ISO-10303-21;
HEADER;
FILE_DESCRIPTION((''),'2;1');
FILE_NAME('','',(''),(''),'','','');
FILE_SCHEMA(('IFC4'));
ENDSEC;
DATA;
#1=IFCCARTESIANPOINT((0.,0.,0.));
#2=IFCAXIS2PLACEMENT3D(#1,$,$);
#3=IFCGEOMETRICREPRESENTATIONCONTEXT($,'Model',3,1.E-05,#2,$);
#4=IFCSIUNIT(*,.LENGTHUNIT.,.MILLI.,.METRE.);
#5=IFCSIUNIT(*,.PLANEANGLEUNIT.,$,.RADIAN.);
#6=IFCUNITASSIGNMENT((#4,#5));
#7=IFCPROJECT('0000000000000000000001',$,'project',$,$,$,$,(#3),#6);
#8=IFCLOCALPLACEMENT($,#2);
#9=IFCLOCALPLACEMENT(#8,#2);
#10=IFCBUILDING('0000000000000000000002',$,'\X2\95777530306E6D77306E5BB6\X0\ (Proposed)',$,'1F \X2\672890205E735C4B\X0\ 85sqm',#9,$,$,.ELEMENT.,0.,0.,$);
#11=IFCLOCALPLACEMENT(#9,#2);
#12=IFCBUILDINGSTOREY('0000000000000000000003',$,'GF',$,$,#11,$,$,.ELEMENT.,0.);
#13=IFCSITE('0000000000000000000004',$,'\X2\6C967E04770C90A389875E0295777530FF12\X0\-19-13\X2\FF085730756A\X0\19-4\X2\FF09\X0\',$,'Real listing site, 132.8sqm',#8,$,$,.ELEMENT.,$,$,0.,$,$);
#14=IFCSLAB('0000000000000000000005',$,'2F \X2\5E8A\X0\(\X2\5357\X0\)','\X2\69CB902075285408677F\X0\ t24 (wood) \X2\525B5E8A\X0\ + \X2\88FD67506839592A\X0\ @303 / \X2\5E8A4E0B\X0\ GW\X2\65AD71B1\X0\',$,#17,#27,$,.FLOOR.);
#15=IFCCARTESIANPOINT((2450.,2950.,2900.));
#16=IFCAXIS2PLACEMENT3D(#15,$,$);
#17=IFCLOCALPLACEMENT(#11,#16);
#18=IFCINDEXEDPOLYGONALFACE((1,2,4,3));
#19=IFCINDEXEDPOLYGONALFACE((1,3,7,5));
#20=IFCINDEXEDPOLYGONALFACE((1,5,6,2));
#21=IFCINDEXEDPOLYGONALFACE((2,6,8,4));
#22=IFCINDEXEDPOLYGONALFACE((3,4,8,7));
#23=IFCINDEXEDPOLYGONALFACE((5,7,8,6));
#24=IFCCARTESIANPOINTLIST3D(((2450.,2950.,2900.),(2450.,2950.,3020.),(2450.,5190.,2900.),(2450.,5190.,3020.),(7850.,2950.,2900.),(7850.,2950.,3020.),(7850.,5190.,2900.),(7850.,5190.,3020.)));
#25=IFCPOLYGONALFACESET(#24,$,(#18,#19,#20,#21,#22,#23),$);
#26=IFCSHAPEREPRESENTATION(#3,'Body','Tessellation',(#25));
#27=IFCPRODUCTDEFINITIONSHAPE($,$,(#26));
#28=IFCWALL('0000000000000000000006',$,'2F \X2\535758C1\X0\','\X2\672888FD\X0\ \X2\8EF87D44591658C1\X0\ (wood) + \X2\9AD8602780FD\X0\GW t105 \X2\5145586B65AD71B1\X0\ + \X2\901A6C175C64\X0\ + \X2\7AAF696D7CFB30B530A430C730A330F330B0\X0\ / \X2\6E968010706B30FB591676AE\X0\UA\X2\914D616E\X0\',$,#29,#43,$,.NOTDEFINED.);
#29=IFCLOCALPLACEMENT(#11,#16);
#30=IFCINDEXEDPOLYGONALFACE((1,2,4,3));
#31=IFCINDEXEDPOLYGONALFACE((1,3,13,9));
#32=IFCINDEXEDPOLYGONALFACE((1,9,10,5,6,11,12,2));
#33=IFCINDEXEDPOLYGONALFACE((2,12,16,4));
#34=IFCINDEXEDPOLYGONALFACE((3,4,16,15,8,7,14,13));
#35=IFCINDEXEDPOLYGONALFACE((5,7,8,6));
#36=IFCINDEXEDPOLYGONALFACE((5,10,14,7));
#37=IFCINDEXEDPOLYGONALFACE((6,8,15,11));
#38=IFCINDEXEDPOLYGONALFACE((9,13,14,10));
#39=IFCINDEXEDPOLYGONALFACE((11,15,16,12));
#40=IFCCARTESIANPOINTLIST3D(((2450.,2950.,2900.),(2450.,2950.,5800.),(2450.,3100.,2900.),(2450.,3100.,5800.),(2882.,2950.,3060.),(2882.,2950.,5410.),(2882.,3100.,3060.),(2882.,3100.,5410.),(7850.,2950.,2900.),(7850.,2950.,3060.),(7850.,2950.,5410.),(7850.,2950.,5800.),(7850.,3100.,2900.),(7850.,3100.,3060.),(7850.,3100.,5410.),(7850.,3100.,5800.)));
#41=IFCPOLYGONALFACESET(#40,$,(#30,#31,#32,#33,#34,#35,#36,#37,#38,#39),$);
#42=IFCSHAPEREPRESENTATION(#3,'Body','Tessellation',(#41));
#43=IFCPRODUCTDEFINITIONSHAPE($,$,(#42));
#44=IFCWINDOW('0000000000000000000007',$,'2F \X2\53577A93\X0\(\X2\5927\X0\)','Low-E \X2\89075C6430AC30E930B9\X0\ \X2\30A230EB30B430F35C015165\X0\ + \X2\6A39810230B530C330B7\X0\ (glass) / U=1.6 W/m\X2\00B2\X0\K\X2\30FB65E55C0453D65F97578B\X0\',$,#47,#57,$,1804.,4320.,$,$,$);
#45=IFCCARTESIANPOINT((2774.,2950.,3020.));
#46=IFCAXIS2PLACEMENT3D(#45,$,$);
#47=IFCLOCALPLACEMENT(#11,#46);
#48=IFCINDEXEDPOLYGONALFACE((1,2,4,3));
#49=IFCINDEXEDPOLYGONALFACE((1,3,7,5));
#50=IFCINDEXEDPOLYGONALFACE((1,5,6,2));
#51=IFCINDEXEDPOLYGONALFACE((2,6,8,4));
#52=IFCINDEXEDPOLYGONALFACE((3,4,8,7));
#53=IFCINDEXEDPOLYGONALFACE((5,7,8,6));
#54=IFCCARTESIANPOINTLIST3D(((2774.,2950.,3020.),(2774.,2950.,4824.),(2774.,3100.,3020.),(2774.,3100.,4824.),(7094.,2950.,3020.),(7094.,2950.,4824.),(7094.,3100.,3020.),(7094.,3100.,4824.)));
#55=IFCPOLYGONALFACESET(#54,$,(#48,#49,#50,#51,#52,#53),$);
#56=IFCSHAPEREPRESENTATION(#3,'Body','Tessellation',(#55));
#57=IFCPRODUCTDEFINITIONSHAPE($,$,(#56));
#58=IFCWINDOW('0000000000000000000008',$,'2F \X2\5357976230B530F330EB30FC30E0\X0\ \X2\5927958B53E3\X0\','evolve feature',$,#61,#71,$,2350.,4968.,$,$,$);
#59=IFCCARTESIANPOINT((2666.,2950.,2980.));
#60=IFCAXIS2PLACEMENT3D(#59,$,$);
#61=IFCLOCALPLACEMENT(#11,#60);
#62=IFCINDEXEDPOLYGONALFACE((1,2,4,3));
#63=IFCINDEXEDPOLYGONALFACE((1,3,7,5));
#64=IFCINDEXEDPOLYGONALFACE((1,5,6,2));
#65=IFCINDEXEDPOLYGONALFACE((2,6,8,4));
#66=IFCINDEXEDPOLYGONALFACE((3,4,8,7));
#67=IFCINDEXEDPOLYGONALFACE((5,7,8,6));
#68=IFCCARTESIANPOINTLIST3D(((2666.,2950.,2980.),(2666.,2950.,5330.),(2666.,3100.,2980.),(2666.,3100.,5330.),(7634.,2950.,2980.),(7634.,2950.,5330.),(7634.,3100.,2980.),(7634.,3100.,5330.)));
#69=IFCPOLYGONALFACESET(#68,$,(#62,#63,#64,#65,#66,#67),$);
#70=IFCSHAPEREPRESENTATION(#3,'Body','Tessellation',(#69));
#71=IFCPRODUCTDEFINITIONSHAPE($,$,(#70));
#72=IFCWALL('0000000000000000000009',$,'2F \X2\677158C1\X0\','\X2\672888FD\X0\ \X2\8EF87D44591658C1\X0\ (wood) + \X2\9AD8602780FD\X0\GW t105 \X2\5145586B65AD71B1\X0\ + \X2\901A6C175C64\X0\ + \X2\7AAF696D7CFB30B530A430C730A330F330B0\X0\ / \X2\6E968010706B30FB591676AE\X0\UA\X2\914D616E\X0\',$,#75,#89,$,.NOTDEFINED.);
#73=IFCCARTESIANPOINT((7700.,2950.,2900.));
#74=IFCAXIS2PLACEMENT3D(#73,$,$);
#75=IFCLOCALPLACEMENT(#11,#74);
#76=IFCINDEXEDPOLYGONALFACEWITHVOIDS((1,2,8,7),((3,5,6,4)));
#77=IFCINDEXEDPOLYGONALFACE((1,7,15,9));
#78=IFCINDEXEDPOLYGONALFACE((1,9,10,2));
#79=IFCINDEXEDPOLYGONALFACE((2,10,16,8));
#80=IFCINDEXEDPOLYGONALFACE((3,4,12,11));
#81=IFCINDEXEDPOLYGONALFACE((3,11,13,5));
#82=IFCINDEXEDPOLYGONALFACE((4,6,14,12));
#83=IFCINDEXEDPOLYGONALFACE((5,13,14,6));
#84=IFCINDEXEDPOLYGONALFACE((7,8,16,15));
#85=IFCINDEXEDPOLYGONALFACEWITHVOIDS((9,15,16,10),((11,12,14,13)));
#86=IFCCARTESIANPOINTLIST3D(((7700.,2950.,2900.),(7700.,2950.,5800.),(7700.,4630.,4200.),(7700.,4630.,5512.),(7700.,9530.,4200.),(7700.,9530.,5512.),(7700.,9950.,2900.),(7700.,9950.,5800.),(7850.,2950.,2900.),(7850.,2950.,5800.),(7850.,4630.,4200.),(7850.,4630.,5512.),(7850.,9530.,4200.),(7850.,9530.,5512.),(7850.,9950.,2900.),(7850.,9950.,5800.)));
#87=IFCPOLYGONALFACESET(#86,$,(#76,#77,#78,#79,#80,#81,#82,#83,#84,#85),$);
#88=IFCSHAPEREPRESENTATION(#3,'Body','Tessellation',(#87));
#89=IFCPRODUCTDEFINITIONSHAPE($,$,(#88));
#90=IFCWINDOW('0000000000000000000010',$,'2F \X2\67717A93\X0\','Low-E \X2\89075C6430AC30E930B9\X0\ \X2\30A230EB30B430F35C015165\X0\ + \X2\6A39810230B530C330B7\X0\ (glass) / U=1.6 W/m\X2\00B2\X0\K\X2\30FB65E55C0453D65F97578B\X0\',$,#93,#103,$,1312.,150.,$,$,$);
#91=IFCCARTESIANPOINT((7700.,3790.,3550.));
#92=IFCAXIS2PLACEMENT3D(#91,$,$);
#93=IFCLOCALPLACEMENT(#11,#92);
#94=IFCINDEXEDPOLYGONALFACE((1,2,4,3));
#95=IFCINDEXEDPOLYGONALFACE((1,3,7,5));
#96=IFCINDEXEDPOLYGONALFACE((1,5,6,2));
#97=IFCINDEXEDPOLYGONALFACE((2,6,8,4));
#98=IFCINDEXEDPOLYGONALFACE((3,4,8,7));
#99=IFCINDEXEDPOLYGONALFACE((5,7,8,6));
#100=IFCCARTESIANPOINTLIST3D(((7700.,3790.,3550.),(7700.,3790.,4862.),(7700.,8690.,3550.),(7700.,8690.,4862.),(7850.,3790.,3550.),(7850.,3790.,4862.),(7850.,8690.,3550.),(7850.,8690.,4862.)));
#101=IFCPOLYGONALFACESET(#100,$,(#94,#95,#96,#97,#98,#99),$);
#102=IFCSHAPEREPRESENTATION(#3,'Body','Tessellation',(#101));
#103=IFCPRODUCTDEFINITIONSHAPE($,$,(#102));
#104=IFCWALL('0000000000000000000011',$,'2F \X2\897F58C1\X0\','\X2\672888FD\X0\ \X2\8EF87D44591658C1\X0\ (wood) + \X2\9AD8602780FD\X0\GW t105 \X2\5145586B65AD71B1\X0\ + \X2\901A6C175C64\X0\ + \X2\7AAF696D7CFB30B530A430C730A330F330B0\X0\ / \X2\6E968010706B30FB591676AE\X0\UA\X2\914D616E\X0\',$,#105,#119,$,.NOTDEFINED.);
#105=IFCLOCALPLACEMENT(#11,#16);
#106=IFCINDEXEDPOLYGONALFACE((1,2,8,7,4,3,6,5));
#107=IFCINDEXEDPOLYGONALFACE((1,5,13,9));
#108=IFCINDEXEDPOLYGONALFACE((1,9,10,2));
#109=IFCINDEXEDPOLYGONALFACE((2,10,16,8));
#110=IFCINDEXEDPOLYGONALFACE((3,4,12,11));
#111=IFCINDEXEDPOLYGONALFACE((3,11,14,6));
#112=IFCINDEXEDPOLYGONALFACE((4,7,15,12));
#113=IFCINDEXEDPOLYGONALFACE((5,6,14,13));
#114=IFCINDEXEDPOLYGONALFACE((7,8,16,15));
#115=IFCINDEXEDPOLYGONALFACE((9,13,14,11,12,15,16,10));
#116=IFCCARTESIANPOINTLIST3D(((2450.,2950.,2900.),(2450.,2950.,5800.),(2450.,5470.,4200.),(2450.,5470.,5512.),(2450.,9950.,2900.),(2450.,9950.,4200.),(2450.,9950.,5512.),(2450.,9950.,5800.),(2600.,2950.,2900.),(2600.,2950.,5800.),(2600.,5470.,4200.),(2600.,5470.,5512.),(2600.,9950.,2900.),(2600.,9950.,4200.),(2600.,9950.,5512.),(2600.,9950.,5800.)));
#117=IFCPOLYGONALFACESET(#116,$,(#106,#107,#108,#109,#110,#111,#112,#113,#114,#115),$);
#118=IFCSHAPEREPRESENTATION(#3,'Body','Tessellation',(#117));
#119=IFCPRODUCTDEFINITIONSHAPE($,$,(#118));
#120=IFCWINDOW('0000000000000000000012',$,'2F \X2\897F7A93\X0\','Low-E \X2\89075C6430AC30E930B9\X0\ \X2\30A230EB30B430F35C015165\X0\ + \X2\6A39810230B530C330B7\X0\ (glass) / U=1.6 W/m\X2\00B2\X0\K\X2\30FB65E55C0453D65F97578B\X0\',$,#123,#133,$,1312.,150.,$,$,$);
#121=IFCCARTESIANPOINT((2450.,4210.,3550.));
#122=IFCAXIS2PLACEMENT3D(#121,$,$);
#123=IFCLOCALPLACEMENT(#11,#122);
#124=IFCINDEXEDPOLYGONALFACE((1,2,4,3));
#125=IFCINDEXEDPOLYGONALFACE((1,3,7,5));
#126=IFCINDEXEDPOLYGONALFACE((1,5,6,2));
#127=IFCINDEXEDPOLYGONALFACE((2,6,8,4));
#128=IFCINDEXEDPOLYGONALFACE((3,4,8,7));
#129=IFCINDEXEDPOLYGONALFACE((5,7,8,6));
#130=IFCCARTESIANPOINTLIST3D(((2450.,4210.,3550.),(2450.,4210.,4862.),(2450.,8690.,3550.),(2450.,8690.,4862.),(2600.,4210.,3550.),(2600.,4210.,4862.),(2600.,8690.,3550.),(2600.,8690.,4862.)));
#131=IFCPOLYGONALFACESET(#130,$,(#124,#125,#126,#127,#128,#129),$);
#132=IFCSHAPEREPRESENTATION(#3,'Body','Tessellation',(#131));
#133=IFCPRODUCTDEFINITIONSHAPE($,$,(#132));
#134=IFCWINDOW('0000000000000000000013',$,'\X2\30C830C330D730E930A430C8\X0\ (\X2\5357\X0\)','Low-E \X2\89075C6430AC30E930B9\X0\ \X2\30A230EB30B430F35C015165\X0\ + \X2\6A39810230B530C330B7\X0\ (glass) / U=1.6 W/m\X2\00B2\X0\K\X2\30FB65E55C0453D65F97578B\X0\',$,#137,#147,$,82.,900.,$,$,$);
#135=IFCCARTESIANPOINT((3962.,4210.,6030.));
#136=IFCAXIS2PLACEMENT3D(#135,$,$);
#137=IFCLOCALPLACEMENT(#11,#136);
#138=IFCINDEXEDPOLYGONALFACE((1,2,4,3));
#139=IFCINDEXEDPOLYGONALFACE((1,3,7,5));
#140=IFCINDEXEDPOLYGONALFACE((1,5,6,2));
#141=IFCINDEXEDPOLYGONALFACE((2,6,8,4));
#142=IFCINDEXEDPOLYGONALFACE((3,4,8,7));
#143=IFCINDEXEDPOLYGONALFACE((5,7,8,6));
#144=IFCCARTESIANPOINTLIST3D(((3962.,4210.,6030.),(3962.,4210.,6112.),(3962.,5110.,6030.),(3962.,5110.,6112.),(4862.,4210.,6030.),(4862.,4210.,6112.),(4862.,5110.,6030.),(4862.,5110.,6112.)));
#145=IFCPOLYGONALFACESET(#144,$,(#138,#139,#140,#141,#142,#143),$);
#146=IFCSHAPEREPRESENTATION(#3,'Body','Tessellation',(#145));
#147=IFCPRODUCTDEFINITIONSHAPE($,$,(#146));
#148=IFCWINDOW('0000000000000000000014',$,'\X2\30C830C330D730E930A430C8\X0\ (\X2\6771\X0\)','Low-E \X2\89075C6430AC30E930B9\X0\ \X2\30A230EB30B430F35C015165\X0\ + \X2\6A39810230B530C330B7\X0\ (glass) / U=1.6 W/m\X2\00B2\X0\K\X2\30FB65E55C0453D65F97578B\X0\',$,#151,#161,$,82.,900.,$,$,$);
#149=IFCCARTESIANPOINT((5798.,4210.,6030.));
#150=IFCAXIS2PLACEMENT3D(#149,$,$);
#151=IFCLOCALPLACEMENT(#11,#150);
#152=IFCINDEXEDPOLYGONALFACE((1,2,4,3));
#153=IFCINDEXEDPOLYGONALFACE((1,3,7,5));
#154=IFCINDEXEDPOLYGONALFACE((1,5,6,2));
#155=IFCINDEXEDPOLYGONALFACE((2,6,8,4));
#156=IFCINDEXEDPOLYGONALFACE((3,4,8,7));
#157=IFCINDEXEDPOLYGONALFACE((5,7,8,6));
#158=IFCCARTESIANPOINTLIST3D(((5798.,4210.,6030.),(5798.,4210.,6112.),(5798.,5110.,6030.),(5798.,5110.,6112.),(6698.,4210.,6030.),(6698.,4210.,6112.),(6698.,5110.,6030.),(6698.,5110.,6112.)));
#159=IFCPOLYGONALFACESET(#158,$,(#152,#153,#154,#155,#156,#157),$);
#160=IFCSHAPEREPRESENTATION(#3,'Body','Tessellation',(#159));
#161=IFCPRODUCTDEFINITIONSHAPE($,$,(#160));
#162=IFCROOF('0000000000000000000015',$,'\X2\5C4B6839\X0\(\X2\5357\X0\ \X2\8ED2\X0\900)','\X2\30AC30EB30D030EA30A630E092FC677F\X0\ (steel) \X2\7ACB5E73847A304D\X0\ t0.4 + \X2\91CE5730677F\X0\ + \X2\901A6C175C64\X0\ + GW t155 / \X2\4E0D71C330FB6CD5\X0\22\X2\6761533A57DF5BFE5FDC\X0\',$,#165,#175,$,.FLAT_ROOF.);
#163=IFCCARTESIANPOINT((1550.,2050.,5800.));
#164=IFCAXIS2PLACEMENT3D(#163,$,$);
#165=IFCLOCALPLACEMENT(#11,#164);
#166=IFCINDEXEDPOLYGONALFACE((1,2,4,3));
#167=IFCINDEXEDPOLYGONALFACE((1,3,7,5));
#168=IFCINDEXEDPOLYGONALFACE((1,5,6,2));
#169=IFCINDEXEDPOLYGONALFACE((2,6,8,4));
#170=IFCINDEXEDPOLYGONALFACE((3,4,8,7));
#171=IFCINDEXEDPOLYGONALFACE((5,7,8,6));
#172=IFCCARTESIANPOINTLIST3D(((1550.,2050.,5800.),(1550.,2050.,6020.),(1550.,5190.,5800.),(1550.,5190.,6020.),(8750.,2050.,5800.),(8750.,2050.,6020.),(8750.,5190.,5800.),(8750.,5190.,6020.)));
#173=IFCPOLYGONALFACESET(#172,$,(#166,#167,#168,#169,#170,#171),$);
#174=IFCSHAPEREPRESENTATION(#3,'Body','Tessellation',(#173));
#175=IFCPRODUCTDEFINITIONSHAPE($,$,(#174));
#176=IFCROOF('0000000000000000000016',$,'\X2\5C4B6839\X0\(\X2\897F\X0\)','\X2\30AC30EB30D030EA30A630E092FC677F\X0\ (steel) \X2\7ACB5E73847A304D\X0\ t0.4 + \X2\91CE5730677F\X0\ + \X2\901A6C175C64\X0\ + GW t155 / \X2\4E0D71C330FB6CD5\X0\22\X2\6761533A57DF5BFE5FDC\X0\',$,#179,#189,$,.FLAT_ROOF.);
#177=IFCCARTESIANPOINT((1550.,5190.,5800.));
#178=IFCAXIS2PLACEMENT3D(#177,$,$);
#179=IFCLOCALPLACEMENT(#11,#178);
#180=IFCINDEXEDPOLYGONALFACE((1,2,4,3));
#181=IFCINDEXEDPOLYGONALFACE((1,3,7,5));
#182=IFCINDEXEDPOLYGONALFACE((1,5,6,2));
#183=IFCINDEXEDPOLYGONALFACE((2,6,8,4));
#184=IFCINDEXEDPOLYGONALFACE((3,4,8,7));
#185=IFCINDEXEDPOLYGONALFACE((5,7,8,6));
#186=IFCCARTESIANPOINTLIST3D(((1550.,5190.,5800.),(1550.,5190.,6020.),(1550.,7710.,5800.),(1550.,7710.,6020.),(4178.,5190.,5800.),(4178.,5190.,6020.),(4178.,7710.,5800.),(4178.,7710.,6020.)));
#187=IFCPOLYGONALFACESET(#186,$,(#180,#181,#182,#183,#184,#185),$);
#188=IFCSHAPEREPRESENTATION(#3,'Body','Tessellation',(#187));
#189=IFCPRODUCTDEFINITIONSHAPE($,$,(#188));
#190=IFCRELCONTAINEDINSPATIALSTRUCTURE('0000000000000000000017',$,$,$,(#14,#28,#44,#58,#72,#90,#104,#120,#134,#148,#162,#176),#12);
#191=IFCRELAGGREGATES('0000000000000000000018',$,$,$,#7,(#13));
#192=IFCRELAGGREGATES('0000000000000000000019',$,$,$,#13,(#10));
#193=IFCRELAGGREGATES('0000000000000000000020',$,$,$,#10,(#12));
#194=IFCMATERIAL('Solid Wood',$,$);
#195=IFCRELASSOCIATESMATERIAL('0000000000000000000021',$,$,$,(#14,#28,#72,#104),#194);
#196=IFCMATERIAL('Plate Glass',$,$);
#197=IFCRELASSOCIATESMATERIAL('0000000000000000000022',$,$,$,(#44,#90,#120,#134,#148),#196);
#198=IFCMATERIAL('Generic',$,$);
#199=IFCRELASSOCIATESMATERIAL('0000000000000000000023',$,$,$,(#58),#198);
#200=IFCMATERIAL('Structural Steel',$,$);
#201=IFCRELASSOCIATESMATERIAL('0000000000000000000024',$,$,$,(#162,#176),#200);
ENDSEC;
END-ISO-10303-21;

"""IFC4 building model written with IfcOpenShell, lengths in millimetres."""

from ifc_helpers import new_model, si_unit, frame, frame_2d, origin, place, context, project, spatial, rectangle, extrude, material, element, fill, save


model = new_model("IFC4")

# Units and contexts
model_context = context("Model", 3, precision=1e-05, world=origin())
ifc_project = project(units=[si_unit("LENGTHUNIT", "METRE", prefix="MILLI"), si_unit("PLANEANGLEUNIT", "RADIAN")], contexts=[model_context])

# Site, building, storey
site_placement = place(None, origin())
site = spatial("IfcSite", under=ifc_project, at=site_placement, Name="沖縄県那覇市長田２-19-13（地番19-4）", ObjectType="Real listing site, 132.8sqm", CompositionType="ELEMENT", RefElevation=0.0)
building_placement = place(site_placement, origin())
building = spatial("IfcBuilding", under=site, at=building_placement, Name="長田の海の家 (Proposed)", ObjectType="1F 木造平屋 85sqm", CompositionType="ELEMENT", ElevationOfRefHeight=0.0, ElevationOfTerrain=0.0)
storey_placement = place(building_placement, origin())
storey = spatial("IfcBuildingStorey", under=building, at=storey_placement, Name="GF", CompositionType="ELEMENT", Elevation=0.0)

# Slab
ifc_material_1 = material(Name="Solid Wood")
slab_placement = place(storey_placement, frame((2450.0, 2950.0, 2900.0)))
element("IfcSlab", 1, at=slab_placement, inside=storey, material=ifc_material_1, Name="2F 床(南)", Description="構造用合板 t24 (wood) 剛床 + 製材根太 @303 / 床下 GW断熱", PredefinedType="FLOOR", context=model_context, shape_type="SweptSolid", body=[
    extrude(rectangle(XDim=5400.0, YDim=2240.0, at=frame_2d((2700.0, 1120.0))), frame((2450.0, 2950.0, 2900.0)), (0.0, 0.0, 1.0), 120.0),
])

# Wall, openings, windows
wall_1_placement = place(storey_placement, frame((2450.0, 2950.0, 2900.0)))
wall_1 = element("IfcWall", 2, at=wall_1_placement, inside=storey, material=ifc_material_1, Name="2F 南壁", Description="木製 軸組外壁 (wood) + 高性能GW t105 充填断熱 + 通気層 + 窯業系サイディング / 準耐火・外皮UA配慮", PredefinedType="NOTDEFINED", context=model_context, shape_type="SweptSolid", body=[
    extrude(rectangle(XDim=5400.0, YDim=150.0, at=frame_2d((2700.0, 75.0))), frame((2450.0, 2950.0, 2900.0)), (0.0, 0.0, 1.0), 2900.0),
])
opening_1_placement = place(storey_placement, frame((2774.0, 2950.0, 3020.0)))
opening_1 = element("IfcOpeningElement", 3, at=opening_1_placement, cuts=wall_1, PredefinedType="NOTDEFINED", context=model_context, shape_type="SweptSolid", body=[
    extrude(rectangle(XDim=4320.0, YDim=150.0, at=frame_2d((2160.0, 75.0))), frame((2774.0, 2950.0, 3020.0)), (0.0, 0.0, 1.0), 1804.0),
])
opening_2_placement = place(storey_placement, frame((2666.0, 2950.0, 2980.0)))
opening_2 = element("IfcOpeningElement", 4, at=opening_2_placement, cuts=wall_1, PredefinedType="NOTDEFINED", context=model_context, shape_type="SweptSolid", body=[
    extrude(rectangle(XDim=4968.0, YDim=150.0, at=frame_2d((2484.0, 75.0))), frame((2666.0, 2950.0, 2980.0)), (0.0, 0.0, 1.0), 2350.0),
])
ifc_material_2 = material(Name="Plate Glass")
window_1_placement = place(storey_placement, frame((2774.0, 2950.0, 3020.0)))
window_1 = element("IfcWindow", 5, at=window_1_placement, inside=storey, material=ifc_material_2, Name="2F 南窓(大)", Description="Low-E 複層ガラス アルゴン封入 + 樹脂サッシ (glass) / U=1.6 W/m²K・日射取得型", OverallHeight=1804.0, OverallWidth=4320.0, context=model_context, shape_type="SweptSolid", body=[
    extrude(rectangle(XDim=4320.0, YDim=150.0, at=frame_2d((2160.0, 75.0))), frame((2774.0, 2950.0, 3020.0)), (0.0, 0.0, 1.0), 1804.0),
])
fill(opening_1, window_1)
ifc_material_3 = material(Name="Generic")
window_2_placement = place(storey_placement, frame((2666.0, 2950.0, 2980.0)))
window_2 = element("IfcWindow", 6, at=window_2_placement, inside=storey, material=ifc_material_3, Name="2F 南面サンルーム 大開口", Description="evolve feature", OverallHeight=2350.0, OverallWidth=4968.0, context=model_context, shape_type="SweptSolid", body=[
    extrude(rectangle(XDim=4968.0, YDim=150.0, at=frame_2d((2484.0, 75.0))), frame((2666.0, 2950.0, 2980.0)), (0.0, 0.0, 1.0), 2350.0),
])
fill(opening_2, window_2)

# Walls, openings, windows
wall_2_placement = place(storey_placement, frame((7700.0, 2950.0, 2900.0)))
wall_2 = element("IfcWall", 7, at=wall_2_placement, inside=storey, material=ifc_material_1, Name="2F 東壁", Description="木製 軸組外壁 (wood) + 高性能GW t105 充填断熱 + 通気層 + 窯業系サイディング / 準耐火・外皮UA配慮", PredefinedType="NOTDEFINED", context=model_context, shape_type="SweptSolid", body=[
    extrude(rectangle(XDim=150.0, YDim=7000.0, at=frame_2d((75.0, 3500.0))), frame((7700.0, 2950.0, 2900.0)), (0.0, 0.0, 1.0), 2900.0),
])
opening_3_placement = place(storey_placement, frame((7700.0, 3790.0, 3550.0)))
opening_3 = element("IfcOpeningElement", 8, at=opening_3_placement, cuts=wall_2, PredefinedType="NOTDEFINED", context=model_context, shape_type="SweptSolid", body=[
    extrude(rectangle(XDim=150.0, YDim=4900.0, at=frame_2d((75.0, 2450.0))), frame((7700.0, 3790.0, 3550.0)), (0.0, 0.0, 1.0), 1312.0),
])
window_3_placement = place(storey_placement, frame((7700.0, 3790.0, 3550.0)))
window_3 = element("IfcWindow", 9, at=window_3_placement, inside=storey, material=ifc_material_2, Name="2F 東窓", Description="Low-E 複層ガラス アルゴン封入 + 樹脂サッシ (glass) / U=1.6 W/m²K・日射取得型", OverallHeight=1312.0, OverallWidth=150.0, context=model_context, shape_type="SweptSolid", body=[
    extrude(rectangle(XDim=150.0, YDim=4900.0, at=frame_2d((75.0, 2450.0))), frame((7700.0, 3790.0, 3550.0)), (0.0, 0.0, 1.0), 1312.0),
])
fill(opening_3, window_3)
wall_3_placement = place(storey_placement, frame((2450.0, 2950.0, 2900.0)))
wall_3 = element("IfcWall", 10, at=wall_3_placement, inside=storey, material=ifc_material_1, Name="2F 西壁", Description="木製 軸組外壁 (wood) + 高性能GW t105 充填断熱 + 通気層 + 窯業系サイディング / 準耐火・外皮UA配慮", PredefinedType="NOTDEFINED", context=model_context, shape_type="SweptSolid", body=[
    extrude(rectangle(XDim=150.0, YDim=7000.0, at=frame_2d((75.0, 3500.0))), frame((2450.0, 2950.0, 2900.0)), (0.0, 0.0, 1.0), 2900.0),
])
opening_4_placement = place(storey_placement, frame((2450.0, 4210.0, 3550.0)))
opening_4 = element("IfcOpeningElement", 11, at=opening_4_placement, cuts=wall_3, PredefinedType="NOTDEFINED", context=model_context, shape_type="SweptSolid", body=[
    extrude(rectangle(XDim=150.0, YDim=4480.0, at=frame_2d((75.0, 2240.0))), frame((2450.0, 4210.0, 3550.0)), (0.0, 0.0, 1.0), 1312.0),
])
window_4_placement = place(storey_placement, frame((2450.0, 4210.0, 3550.0)))
window_4 = element("IfcWindow", 12, at=window_4_placement, inside=storey, material=ifc_material_2, Name="2F 西窓", Description="Low-E 複層ガラス アルゴン封入 + 樹脂サッシ (glass) / U=1.6 W/m²K・日射取得型", OverallHeight=1312.0, OverallWidth=150.0, context=model_context, shape_type="SweptSolid", body=[
    extrude(rectangle(XDim=150.0, YDim=4480.0, at=frame_2d((75.0, 2240.0))), frame((2450.0, 4210.0, 3550.0)), (0.0, 0.0, 1.0), 1312.0),
])
fill(opening_4, window_4)

# Windows
window_5_placement = place(storey_placement, frame((3962.0, 4210.0, 6030.0)))
element("IfcWindow", 13, at=window_5_placement, inside=storey, material=ifc_material_2, Name="トップライト (南)", Description="Low-E 複層ガラス アルゴン封入 + 樹脂サッシ (glass) / U=1.6 W/m²K・日射取得型", OverallHeight=82.0, OverallWidth=900.0, context=model_context, shape_type="SweptSolid", body=[
    extrude(rectangle(XDim=900.0, YDim=900.0, at=frame_2d((450.0, 450.0))), frame((3962.0, 4210.0, 6030.0)), (0.0, 0.0, 1.0), 82.0),
])
window_6_placement = place(storey_placement, frame((5798.0, 4210.0, 6030.0)))
element("IfcWindow", 14, at=window_6_placement, inside=storey, material=ifc_material_2, Name="トップライト (東)", Description="Low-E 複層ガラス アルゴン封入 + 樹脂サッシ (glass) / U=1.6 W/m²K・日射取得型", OverallHeight=82.0, OverallWidth=900.0, context=model_context, shape_type="SweptSolid", body=[
    extrude(rectangle(XDim=900.0, YDim=900.0, at=frame_2d((450.0, 450.0))), frame((5798.0, 4210.0, 6030.0)), (0.0, 0.0, 1.0), 82.0),
])

# Roofs
ifc_material_4 = material(Name="Structural Steel")
roof_1_placement = place(storey_placement, frame((1550.0, 2050.0, 5800.0)))
element("IfcRoof", 15, at=roof_1_placement, inside=storey, material=ifc_material_4, Name="屋根(南 軒900)", Description="ガルバリウム鋼板 (steel) 立平葺き t0.4 + 野地板 + 通気層 + GW t155 / 不燃・法22条区域対応", PredefinedType="FLAT_ROOF", context=model_context, shape_type="SweptSolid", body=[
    extrude(rectangle(XDim=7200.0, YDim=3140.0, at=frame_2d((3600.0, 1570.0))), frame((1550.0, 2050.0, 5800.0)), (0.0, 0.0, 1.0), 220.0),
])
roof_2_placement = place(storey_placement, frame((1550.0, 5190.0, 5800.0)))
element("IfcRoof", 16, at=roof_2_placement, inside=storey, material=ifc_material_4, Name="屋根(西)", Description="ガルバリウム鋼板 (steel) 立平葺き t0.4 + 野地板 + 通気層 + GW t155 / 不燃・法22条区域対応", PredefinedType="FLAT_ROOF", context=model_context, shape_type="SweptSolid", body=[
    extrude(rectangle(XDim=2628.0, YDim=2520.0, at=frame_2d((1314.0, 1260.0))), frame((1550.0, 5190.0, 5800.0)), (0.0, 0.0, 1.0), 220.0),
])

save(model, "model.ifc")
